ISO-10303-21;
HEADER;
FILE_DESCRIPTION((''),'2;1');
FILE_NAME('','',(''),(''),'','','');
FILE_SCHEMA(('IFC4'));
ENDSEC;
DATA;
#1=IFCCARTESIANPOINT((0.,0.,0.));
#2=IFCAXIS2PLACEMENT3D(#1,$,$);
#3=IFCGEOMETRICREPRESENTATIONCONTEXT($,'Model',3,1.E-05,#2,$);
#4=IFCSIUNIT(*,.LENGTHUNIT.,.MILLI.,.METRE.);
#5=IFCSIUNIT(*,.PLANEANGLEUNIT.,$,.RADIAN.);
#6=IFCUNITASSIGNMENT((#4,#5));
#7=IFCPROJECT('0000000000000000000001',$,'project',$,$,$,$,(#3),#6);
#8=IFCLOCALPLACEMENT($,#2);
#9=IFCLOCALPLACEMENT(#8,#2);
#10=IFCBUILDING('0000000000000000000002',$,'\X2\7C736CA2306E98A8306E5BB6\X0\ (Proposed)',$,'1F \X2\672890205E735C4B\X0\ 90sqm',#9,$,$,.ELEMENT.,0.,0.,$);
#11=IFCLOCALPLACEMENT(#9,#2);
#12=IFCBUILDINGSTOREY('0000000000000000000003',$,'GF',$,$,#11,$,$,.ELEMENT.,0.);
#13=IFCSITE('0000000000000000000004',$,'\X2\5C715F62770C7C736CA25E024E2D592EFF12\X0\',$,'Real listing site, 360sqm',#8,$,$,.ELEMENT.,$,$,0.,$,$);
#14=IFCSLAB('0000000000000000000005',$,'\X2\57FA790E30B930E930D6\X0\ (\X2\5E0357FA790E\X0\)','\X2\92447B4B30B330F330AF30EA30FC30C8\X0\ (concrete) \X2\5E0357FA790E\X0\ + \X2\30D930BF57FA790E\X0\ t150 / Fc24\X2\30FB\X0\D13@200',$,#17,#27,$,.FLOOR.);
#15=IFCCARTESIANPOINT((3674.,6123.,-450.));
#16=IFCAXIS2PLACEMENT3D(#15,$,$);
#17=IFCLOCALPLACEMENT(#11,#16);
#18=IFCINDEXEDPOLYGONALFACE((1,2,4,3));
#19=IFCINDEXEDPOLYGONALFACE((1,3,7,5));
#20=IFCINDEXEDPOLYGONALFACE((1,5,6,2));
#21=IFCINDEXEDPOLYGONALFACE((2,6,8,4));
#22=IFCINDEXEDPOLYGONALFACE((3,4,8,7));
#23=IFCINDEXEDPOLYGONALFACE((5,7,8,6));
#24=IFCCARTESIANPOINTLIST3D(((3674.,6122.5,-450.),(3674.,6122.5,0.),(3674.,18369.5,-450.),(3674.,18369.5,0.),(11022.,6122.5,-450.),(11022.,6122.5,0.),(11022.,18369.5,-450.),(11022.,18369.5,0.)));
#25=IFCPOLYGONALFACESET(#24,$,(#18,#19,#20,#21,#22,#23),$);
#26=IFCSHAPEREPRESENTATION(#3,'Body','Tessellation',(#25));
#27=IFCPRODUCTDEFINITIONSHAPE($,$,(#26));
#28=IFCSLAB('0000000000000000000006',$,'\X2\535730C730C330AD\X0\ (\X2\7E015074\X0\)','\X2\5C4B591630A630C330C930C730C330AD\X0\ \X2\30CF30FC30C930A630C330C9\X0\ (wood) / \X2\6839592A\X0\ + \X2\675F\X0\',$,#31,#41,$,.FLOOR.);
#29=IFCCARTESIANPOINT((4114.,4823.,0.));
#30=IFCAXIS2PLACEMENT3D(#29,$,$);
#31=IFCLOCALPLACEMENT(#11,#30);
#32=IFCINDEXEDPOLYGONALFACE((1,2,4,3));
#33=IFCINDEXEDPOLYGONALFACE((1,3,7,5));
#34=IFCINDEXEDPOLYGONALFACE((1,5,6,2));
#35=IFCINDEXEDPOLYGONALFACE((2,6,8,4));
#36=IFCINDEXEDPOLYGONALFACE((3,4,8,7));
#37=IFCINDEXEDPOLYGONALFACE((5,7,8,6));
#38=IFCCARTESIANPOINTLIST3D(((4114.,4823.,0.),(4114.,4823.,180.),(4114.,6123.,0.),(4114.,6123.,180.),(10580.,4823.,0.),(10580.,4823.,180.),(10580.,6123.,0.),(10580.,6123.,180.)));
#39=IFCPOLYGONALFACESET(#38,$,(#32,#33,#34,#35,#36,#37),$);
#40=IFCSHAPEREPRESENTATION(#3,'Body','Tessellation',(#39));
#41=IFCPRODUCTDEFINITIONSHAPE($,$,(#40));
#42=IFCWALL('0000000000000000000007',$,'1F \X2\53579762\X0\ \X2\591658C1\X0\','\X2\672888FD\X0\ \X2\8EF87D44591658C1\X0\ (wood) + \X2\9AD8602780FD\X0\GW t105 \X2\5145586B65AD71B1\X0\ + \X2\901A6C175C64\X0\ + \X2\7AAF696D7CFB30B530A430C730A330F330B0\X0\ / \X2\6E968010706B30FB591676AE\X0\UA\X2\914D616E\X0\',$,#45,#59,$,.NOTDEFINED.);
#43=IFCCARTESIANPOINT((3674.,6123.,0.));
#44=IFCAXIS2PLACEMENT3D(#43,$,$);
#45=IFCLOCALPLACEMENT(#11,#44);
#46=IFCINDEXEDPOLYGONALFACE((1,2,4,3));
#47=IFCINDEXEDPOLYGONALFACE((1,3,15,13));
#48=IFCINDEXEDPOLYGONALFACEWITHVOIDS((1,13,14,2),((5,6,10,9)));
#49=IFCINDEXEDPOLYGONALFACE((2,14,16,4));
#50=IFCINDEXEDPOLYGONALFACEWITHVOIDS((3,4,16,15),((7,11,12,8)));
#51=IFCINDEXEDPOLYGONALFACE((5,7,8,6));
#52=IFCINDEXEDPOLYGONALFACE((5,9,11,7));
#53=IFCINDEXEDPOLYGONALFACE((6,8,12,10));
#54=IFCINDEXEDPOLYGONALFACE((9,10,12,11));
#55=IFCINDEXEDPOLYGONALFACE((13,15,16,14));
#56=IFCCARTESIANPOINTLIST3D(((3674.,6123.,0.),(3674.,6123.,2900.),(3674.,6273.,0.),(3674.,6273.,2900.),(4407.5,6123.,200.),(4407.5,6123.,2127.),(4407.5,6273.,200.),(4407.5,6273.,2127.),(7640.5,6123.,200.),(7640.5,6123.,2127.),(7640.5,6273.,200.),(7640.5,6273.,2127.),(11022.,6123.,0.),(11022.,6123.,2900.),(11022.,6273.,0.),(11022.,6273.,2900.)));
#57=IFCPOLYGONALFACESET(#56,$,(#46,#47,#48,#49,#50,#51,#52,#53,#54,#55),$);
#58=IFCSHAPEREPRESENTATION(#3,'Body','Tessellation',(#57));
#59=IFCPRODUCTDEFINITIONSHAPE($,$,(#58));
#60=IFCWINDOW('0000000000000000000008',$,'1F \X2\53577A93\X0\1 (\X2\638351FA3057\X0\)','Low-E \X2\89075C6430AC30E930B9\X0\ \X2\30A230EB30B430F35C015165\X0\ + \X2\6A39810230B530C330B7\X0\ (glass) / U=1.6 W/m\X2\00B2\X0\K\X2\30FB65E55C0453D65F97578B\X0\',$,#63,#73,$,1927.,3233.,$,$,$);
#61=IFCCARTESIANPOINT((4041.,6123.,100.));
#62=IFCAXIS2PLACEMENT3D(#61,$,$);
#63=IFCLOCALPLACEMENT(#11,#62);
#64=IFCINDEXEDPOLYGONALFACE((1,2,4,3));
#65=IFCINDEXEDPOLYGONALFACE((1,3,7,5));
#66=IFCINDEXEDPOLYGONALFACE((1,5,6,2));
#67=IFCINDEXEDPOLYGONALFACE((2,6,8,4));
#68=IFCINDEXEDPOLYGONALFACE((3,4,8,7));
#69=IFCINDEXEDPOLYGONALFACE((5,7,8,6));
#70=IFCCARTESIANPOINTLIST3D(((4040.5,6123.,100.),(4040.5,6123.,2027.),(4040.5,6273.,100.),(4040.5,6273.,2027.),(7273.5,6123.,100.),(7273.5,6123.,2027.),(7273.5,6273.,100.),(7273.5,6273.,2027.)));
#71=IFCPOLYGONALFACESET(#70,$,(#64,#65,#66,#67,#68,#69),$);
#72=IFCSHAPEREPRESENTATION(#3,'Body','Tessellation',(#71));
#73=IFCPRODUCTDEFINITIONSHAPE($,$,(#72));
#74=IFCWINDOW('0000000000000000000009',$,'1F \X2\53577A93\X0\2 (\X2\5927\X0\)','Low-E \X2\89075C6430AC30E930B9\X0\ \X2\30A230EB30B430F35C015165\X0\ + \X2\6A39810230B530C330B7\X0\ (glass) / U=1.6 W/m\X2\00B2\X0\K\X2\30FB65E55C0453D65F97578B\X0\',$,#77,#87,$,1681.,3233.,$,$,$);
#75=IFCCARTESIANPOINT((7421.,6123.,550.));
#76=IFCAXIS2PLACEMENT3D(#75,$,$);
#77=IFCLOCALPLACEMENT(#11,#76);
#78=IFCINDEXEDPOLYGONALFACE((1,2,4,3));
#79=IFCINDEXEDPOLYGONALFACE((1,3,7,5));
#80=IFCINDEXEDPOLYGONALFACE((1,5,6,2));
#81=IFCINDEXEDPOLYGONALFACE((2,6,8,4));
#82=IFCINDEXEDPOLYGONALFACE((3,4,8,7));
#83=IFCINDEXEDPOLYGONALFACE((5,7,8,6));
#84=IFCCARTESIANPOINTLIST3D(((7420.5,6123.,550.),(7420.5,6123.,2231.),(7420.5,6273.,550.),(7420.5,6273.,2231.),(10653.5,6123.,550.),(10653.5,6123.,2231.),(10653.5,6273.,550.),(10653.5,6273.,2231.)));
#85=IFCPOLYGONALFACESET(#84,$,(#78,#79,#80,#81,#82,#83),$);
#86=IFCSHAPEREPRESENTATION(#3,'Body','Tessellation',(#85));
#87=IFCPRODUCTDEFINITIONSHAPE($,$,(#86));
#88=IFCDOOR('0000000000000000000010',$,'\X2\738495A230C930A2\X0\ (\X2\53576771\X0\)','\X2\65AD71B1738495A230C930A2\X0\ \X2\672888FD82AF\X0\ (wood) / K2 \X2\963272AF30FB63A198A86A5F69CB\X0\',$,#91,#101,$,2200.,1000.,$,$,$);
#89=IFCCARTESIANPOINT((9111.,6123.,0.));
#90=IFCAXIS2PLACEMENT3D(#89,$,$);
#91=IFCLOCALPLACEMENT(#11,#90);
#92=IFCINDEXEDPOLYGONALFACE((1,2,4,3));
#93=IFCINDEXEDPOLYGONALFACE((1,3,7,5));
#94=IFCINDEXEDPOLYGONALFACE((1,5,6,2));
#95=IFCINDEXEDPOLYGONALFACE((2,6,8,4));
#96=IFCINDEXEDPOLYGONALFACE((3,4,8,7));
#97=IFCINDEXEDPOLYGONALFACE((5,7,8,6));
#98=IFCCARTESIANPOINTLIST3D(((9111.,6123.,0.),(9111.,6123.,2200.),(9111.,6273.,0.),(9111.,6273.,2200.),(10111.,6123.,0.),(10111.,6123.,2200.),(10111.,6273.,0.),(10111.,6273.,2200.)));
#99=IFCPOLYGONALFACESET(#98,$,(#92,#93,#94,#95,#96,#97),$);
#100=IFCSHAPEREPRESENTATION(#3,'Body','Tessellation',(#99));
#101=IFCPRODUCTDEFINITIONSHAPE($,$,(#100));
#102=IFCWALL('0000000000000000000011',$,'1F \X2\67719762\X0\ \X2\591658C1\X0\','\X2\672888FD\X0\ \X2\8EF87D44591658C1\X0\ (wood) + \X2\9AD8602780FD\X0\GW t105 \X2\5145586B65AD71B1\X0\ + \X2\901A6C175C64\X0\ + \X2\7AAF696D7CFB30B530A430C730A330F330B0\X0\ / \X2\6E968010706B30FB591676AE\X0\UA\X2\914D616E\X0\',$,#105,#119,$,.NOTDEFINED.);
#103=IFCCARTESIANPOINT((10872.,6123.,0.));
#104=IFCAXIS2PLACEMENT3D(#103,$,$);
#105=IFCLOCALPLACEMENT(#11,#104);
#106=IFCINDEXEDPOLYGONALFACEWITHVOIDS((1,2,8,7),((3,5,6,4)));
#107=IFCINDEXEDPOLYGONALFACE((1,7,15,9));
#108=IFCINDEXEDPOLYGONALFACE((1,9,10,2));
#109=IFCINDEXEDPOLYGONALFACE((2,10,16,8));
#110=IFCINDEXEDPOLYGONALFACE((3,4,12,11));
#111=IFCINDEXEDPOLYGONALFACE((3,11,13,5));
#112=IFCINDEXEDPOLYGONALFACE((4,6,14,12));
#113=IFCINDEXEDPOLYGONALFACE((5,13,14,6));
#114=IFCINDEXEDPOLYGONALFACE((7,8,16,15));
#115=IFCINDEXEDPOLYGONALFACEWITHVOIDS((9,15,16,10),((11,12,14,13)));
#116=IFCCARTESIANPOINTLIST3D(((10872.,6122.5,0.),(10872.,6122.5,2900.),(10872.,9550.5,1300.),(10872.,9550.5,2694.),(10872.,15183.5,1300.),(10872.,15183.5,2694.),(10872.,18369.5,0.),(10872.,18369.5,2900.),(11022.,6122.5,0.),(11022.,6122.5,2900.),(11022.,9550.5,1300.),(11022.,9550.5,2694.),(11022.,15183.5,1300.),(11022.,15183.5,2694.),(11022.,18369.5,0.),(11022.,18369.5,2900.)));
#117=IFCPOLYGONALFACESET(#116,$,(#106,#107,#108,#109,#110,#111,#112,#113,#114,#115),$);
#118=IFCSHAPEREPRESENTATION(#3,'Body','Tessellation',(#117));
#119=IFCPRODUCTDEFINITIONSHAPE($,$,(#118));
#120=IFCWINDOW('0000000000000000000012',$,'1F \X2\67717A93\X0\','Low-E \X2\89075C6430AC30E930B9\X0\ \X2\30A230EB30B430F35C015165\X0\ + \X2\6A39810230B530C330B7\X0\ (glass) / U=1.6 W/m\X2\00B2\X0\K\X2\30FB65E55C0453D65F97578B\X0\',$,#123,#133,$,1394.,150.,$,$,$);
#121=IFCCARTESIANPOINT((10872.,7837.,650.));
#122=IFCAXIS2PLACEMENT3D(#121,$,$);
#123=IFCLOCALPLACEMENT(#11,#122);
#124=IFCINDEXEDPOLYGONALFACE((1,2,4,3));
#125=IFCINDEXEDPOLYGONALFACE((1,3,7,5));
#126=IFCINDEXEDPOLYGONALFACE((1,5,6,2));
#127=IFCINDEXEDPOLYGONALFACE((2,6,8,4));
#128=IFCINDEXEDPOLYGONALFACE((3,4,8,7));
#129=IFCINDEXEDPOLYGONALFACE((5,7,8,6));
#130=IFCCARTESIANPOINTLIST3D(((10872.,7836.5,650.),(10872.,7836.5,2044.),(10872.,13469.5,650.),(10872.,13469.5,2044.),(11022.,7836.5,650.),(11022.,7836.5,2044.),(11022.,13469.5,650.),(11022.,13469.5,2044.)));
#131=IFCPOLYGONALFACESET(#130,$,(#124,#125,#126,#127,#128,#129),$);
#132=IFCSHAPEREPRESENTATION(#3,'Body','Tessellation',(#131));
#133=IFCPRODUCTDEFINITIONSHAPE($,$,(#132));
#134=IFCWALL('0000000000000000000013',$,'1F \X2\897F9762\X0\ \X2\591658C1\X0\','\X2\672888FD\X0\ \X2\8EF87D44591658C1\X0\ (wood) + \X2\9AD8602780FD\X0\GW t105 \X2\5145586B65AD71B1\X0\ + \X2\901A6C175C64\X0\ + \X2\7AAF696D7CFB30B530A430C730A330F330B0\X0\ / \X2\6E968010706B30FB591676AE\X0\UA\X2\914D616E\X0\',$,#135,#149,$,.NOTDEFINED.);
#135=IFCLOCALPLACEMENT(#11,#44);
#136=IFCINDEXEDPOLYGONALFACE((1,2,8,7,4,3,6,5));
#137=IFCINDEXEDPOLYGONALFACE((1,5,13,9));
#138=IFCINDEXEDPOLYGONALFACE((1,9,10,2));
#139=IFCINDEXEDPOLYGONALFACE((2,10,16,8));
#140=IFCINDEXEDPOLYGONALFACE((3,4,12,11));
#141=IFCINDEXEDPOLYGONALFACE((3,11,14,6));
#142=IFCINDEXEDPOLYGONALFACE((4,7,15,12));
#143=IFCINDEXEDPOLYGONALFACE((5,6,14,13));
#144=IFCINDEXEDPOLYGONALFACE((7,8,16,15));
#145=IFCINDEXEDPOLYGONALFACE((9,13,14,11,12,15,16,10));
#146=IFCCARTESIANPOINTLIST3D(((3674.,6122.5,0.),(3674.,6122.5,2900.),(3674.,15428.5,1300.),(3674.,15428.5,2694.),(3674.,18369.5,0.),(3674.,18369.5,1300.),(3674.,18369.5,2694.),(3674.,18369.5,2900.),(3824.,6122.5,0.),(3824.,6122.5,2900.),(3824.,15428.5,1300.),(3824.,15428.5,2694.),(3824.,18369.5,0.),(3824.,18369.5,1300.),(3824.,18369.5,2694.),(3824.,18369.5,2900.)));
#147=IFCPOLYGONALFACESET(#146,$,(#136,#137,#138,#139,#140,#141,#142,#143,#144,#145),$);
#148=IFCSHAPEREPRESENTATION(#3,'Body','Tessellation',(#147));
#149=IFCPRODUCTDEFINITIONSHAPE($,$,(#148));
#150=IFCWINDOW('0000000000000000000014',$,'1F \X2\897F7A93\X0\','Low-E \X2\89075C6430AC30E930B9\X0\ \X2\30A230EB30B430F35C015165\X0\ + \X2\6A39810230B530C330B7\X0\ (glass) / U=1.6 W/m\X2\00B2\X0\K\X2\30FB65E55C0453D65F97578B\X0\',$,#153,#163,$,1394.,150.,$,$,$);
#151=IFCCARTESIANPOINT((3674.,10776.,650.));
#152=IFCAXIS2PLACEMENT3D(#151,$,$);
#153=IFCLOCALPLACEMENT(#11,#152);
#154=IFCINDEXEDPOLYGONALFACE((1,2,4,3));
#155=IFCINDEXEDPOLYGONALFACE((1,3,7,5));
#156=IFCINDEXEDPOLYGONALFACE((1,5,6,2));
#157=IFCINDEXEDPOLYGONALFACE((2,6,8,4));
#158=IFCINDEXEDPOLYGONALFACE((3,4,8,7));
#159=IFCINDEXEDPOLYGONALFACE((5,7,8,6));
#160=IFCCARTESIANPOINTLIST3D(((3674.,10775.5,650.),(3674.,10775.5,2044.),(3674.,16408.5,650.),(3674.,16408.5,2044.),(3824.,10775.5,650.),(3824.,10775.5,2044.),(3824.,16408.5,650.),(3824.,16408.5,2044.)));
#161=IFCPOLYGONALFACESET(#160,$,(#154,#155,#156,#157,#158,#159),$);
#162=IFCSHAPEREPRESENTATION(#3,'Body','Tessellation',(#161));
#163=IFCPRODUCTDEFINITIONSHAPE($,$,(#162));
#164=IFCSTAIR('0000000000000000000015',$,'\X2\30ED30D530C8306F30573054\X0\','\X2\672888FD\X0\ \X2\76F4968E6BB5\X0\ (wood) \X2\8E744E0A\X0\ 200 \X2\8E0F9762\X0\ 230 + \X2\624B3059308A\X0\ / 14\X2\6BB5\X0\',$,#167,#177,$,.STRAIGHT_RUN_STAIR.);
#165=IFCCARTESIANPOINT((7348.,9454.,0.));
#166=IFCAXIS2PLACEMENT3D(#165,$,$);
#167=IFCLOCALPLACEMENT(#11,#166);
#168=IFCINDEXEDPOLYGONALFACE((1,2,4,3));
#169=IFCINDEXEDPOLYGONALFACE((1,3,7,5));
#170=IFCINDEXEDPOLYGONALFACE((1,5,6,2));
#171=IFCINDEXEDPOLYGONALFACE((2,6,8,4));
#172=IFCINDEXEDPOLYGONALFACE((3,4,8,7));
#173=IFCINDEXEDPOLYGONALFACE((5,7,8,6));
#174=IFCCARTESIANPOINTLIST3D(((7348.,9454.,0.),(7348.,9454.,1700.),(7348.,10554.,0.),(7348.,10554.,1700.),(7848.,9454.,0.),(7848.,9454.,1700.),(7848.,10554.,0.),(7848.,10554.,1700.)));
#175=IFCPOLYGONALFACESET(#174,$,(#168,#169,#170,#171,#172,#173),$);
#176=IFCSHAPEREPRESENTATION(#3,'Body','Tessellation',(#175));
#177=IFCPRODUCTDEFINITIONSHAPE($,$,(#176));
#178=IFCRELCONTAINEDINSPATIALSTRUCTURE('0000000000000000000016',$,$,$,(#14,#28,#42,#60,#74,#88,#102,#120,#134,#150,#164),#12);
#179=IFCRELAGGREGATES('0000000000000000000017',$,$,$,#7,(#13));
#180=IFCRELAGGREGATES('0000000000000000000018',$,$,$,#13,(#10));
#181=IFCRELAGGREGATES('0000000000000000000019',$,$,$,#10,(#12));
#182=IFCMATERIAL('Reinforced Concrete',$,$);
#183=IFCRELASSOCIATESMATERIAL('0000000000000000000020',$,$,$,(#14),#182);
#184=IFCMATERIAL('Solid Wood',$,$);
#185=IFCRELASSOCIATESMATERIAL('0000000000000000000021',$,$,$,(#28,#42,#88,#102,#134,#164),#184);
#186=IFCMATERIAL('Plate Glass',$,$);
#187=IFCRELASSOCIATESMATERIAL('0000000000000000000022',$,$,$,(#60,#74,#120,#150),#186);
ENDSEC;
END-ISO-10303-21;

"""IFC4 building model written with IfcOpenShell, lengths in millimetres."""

from ifc_helpers import new_model, si_unit, frame, frame_2d, origin, place, context, project, spatial, rectangle, extrude, material, element, fill, save


model = new_model("IFC4")

# Units and contexts
model_context = context("Model", 3, precision=1e-05, world=origin())
ifc_project = project(units=[si_unit("LENGTHUNIT", "METRE", prefix="MILLI"), si_unit("PLANEANGLEUNIT", "RADIAN")], contexts=[model_context])

# Site, building, storey
site_placement = place(None, origin())
site = spatial("IfcSite", under=ifc_project, at=site_placement, Name="山形県米沢市中央２", ObjectType="Real listing site, 360sqm", CompositionType="ELEMENT", RefElevation=0.0)
building_placement = place(site_placement, origin())
building = spatial("IfcBuilding", under=site, at=building_placement, Name="米沢の風の家 (Proposed)", ObjectType="1F 木造平屋 90sqm", CompositionType="ELEMENT", ElevationOfRefHeight=0.0, ElevationOfTerrain=0.0)
storey_placement = place(building_placement, origin())
storey = spatial("IfcBuildingStorey", under=building, at=storey_placement, Name="GF", CompositionType="ELEMENT", Elevation=0.0)

# Slabs
ifc_material_1 = material(Name="Reinforced Concrete")
slab_1_placement = place(storey_placement, frame((3674.0, 6123.0, -450.0)))
element("IfcSlab", 1, at=slab_1_placement, inside=storey, material=ifc_material_1, Name="基礎スラブ (布基礎)", Description="鉄筋コンクリート (concrete) 布基礎 + ベタ基礎 t150 / Fc24・D13@200", PredefinedType="FLOOR", context=model_context, shape_type="SweptSolid", body=[
    extrude(rectangle(XDim=7348.0, YDim=12247.0, at=frame_2d((3674.0, 6123.0))), frame((3674.0, 6123.0, -450.0)), (0.0, 0.0, 1.0), 450.0),
])
ifc_material_2 = material(Name="Solid Wood")
slab_2_placement = place(storey_placement, frame((4114.0, 4823.0, 0.0)))
element("IfcSlab", 2, at=slab_2_placement, inside=storey, material=ifc_material_2, Name="南デッキ (縁側)", Description="屋外ウッドデッキ ハードウッド (wood) / 根太 + 束", PredefinedType="FLOOR", context=model_context, shape_type="SweptSolid", body=[
    extrude(rectangle(XDim=6466.0, YDim=1300.0, at=frame_2d((3233.0, 650.0))), frame((4114.0, 4823.0, 0.0)), (0.0, 0.0, 1.0), 180.0),
])

# Wall, openings, windows, door
wall_1_placement = place(storey_placement, frame((3674.0, 6123.0, 0.0)))
wall_1 = element("IfcWall", 3, at=wall_1_placement, inside=storey, material=ifc_material_2, Name="1F 南面 外壁", Description="木製 軸組外壁 (wood) + 高性能GW t105 充填断熱 + 通気層 + 窯業系サイディング / 準耐火・外皮UA配慮", PredefinedType="NOTDEFINED", context=model_context, shape_type="SweptSolid", body=[
    extrude(rectangle(XDim=7348.0, YDim=150.0, at=frame_2d((3674.0, 75.0))), frame((3674.0, 6123.0, 0.0)), (0.0, 0.0, 1.0), 2900.0),
])
opening_1_placement = place(storey_placement, frame((4041.0, 6123.0, 100.0)))
opening_1 = element("IfcOpeningElement", 4, at=opening_1_placement, cuts=wall_1, PredefinedType="NOTDEFINED", context=model_context, shape_type="SweptSolid", body=[
    extrude(rectangle(XDim=3233.0, YDim=150.0, at=frame_2d((1616.0, 75.0))), frame((4041.0, 6123.0, 100.0)), (0.0, 0.0, 1.0), 1927.0),
])
opening_2_placement = place(storey_placement, frame((7421.0, 6123.0, 550.0)))
opening_2 = element("IfcOpeningElement", 5, at=opening_2_placement, cuts=wall_1, PredefinedType="NOTDEFINED", context=model_context, shape_type="SweptSolid", body=[
    extrude(rectangle(XDim=3233.0, YDim=150.0, at=frame_2d((1616.0, 75.0))), frame((7421.0, 6123.0, 550.0)), (0.0, 0.0, 1.0), 1681.0),
])
opening_3_placement = place(storey_placement, frame((9111.0, 6123.0, 0.0)))
opening_3 = element("IfcOpeningElement", 6, at=opening_3_placement, cuts=wall_1, PredefinedType="NOTDEFINED", context=model_context, shape_type="SweptSolid", body=[
    extrude(rectangle(XDim=1000.0, YDim=150.0, at=frame_2d((500.0, 75.0))), frame((9111.0, 6123.0, 0.0)), (0.0, 0.0, 1.0), 2200.0),
])
ifc_material_3 = material(Name="Plate Glass")
window_1_placement = place(storey_placement, frame((4041.0, 6123.0, 100.0)))
window_1 = element("IfcWindow", 7, at=window_1_placement, inside=storey, material=ifc_material_3, Name="1F 南窓1 (掃出し)", Description="Low-E 複層ガラス アルゴン封入 + 樹脂サッシ (glass) / U=1.6 W/m²K・日射取得型", OverallHeight=1927.0, OverallWidth=3233.0, context=model_context, shape_type="SweptSolid", body=[
    extrude(rectangle(XDim=3233.0, YDim=150.0, at=frame_2d((1616.0, 75.0))), frame((4041.0, 6123.0, 100.0)), (0.0, 0.0, 1.0), 1927.0),
])
fill(opening_1, window_1)
window_2_placement = place(storey_placement, frame((7421.0, 6123.0, 550.0)))
window_2 = element("IfcWindow", 8, at=window_2_placement, inside=storey, material=ifc_material_3, Name="1F 南窓2 (大)", Description="Low-E 複層ガラス アルゴン封入 + 樹脂サッシ (glass) / U=1.6 W/m²K・日射取得型", OverallHeight=1681.0, OverallWidth=3233.0, context=model_context, shape_type="SweptSolid", body=[
    extrude(rectangle(XDim=3233.0, YDim=150.0, at=frame_2d((1616.0, 75.0))), frame((7421.0, 6123.0, 550.0)), (0.0, 0.0, 1.0), 1681.0),
])
fill(opening_2, window_2)
door_placement = place(storey_placement, frame((9111.0, 6123.0, 0.0)))
door = element("IfcDoor", 9, at=door_placement, inside=storey, material=ifc_material_2, Name="玄関ドア (南東)", Description="断熱玄関ドア 木製芯 (wood) / K2 防犯・採風機構", OverallHeight=2200.0, OverallWidth=1000.0, context=model_context, shape_type="SweptSolid", body=[
    extrude(rectangle(XDim=1000.0, YDim=150.0, at=frame_2d((500.0, 75.0))), frame((9111.0, 6123.0, 0.0)), (0.0, 0.0, 1.0), 2200.0),
])
fill(opening_3, door)

# Walls, openings, windows
wall_2_placement = place(storey_placement, frame((10872.0, 6123.0, 0.0)))
wall_2 = element("IfcWall", 10, at=wall_2_placement, inside=storey, material=ifc_material_2, Name="1F 東面 外壁", Description="木製 軸組外壁 (wood) + 高性能GW t105 充填断熱 + 通気層 + 窯業系サイディング / 準耐火・外皮UA配慮", PredefinedType="NOTDEFINED", context=model_context, shape_type="SweptSolid", body=[
    extrude(rectangle(XDim=150.0, YDim=12247.0, at=frame_2d((75.0, 6123.0))), frame((10872.0, 6123.0, 0.0)), (0.0, 0.0, 1.0), 2900.0),
])
opening_4_placement = place(storey_placement, frame((10872.0, 7837.0, 650.0)))
opening_4 = element("IfcOpeningElement", 11, at=opening_4_placement, cuts=wall_2, PredefinedType="NOTDEFINED", context=model_context, shape_type="SweptSolid", body=[
    extrude(rectangle(XDim=150.0, YDim=5633.0, at=frame_2d((75.0, 2816.0))), frame((10872.0, 7837.0, 650.0)), (0.0, 0.0, 1.0), 1394.0),
])
window_3_placement = place(storey_placement, frame((10872.0, 7837.0, 650.0)))
window_3 = element("IfcWindow", 12, at=window_3_placement, inside=storey, material=ifc_material_3, Name="1F 東窓", Description="Low-E 複層ガラス アルゴン封入 + 樹脂サッシ (glass) / U=1.6 W/m²K・日射取得型", OverallHeight=1394.0, OverallWidth=150.0, context=model_context, shape_type="SweptSolid", body=[
    extrude(rectangle(XDim=150.0, YDim=5633.0, at=frame_2d((75.0, 2816.0))), frame((10872.0, 7837.0, 650.0)), (0.0, 0.0, 1.0), 1394.0),
])
fill(opening_4, window_3)
wall_3_placement = place(storey_placement, frame((3674.0, 6123.0, 0.0)))
wall_3 = element("IfcWall", 13, at=wall_3_placement, inside=storey, material=ifc_material_2, Name="1F 西面 外壁", Description="木製 軸組外壁 (wood) + 高性能GW t105 充填断熱 + 通気層 + 窯業系サイディング / 準耐火・外皮UA配慮", PredefinedType="NOTDEFINED", context=model_context, shape_type="SweptSolid", body=[
    extrude(rectangle(XDim=150.0, YDim=12247.0, at=frame_2d((75.0, 6123.0))), frame((3674.0, 6123.0, 0.0)), (0.0, 0.0, 1.0), 2900.0),
])
opening_5_placement = place(storey_placement, frame((3674.0, 10776.0, 650.0)))
opening_5 = element("IfcOpeningElement", 14, at=opening_5_placement, cuts=wall_3, PredefinedType="NOTDEFINED", context=model_context, shape_type="SweptSolid", body=[
    extrude(rectangle(XDim=150.0, YDim=5633.0, at=frame_2d((75.0, 2816.0))), frame((3674.0, 10776.0, 650.0)), (0.0, 0.0, 1.0), 1394.0),
])
window_4_placement = place(storey_placement, frame((3674.0, 10776.0, 650.0)))
window_4 = element("IfcWindow", 15, at=window_4_placement, inside=storey, material=ifc_material_3, Name="1F 西窓", Description="Low-E 複層ガラス アルゴン封入 + 樹脂サッシ (glass) / U=1.6 W/m²K・日射取得型", OverallHeight=1394.0, OverallWidth=150.0, context=model_context, shape_type="SweptSolid", body=[
    extrude(rectangle(XDim=150.0, YDim=5633.0, at=frame_2d((75.0, 2816.0))), frame((3674.0, 10776.0, 650.0)), (0.0, 0.0, 1.0), 1394.0),
])
fill(opening_5, window_4)

# Stair
stair_placement = place(storey_placement, frame((7348.0, 9454.0, 0.0)))
element("IfcStair", 16, at=stair_placement, inside=storey, material=ifc_material_2, Name="ロフトはしご", Description="木製 直階段 (wood) 蹴上 200 踏面 230 + 手すり / 14段", PredefinedType="STRAIGHT_RUN_STAIR", context=model_context, shape_type="SweptSolid", body=[
    extrude(rectangle(XDim=500.0, YDim=1100.0, at=frame_2d((250.0, 550.0))), frame((7348.0, 9454.0, 0.0)), (0.0, 0.0, 1.0), 1700.0),
])

save(model, "model.ifc")
